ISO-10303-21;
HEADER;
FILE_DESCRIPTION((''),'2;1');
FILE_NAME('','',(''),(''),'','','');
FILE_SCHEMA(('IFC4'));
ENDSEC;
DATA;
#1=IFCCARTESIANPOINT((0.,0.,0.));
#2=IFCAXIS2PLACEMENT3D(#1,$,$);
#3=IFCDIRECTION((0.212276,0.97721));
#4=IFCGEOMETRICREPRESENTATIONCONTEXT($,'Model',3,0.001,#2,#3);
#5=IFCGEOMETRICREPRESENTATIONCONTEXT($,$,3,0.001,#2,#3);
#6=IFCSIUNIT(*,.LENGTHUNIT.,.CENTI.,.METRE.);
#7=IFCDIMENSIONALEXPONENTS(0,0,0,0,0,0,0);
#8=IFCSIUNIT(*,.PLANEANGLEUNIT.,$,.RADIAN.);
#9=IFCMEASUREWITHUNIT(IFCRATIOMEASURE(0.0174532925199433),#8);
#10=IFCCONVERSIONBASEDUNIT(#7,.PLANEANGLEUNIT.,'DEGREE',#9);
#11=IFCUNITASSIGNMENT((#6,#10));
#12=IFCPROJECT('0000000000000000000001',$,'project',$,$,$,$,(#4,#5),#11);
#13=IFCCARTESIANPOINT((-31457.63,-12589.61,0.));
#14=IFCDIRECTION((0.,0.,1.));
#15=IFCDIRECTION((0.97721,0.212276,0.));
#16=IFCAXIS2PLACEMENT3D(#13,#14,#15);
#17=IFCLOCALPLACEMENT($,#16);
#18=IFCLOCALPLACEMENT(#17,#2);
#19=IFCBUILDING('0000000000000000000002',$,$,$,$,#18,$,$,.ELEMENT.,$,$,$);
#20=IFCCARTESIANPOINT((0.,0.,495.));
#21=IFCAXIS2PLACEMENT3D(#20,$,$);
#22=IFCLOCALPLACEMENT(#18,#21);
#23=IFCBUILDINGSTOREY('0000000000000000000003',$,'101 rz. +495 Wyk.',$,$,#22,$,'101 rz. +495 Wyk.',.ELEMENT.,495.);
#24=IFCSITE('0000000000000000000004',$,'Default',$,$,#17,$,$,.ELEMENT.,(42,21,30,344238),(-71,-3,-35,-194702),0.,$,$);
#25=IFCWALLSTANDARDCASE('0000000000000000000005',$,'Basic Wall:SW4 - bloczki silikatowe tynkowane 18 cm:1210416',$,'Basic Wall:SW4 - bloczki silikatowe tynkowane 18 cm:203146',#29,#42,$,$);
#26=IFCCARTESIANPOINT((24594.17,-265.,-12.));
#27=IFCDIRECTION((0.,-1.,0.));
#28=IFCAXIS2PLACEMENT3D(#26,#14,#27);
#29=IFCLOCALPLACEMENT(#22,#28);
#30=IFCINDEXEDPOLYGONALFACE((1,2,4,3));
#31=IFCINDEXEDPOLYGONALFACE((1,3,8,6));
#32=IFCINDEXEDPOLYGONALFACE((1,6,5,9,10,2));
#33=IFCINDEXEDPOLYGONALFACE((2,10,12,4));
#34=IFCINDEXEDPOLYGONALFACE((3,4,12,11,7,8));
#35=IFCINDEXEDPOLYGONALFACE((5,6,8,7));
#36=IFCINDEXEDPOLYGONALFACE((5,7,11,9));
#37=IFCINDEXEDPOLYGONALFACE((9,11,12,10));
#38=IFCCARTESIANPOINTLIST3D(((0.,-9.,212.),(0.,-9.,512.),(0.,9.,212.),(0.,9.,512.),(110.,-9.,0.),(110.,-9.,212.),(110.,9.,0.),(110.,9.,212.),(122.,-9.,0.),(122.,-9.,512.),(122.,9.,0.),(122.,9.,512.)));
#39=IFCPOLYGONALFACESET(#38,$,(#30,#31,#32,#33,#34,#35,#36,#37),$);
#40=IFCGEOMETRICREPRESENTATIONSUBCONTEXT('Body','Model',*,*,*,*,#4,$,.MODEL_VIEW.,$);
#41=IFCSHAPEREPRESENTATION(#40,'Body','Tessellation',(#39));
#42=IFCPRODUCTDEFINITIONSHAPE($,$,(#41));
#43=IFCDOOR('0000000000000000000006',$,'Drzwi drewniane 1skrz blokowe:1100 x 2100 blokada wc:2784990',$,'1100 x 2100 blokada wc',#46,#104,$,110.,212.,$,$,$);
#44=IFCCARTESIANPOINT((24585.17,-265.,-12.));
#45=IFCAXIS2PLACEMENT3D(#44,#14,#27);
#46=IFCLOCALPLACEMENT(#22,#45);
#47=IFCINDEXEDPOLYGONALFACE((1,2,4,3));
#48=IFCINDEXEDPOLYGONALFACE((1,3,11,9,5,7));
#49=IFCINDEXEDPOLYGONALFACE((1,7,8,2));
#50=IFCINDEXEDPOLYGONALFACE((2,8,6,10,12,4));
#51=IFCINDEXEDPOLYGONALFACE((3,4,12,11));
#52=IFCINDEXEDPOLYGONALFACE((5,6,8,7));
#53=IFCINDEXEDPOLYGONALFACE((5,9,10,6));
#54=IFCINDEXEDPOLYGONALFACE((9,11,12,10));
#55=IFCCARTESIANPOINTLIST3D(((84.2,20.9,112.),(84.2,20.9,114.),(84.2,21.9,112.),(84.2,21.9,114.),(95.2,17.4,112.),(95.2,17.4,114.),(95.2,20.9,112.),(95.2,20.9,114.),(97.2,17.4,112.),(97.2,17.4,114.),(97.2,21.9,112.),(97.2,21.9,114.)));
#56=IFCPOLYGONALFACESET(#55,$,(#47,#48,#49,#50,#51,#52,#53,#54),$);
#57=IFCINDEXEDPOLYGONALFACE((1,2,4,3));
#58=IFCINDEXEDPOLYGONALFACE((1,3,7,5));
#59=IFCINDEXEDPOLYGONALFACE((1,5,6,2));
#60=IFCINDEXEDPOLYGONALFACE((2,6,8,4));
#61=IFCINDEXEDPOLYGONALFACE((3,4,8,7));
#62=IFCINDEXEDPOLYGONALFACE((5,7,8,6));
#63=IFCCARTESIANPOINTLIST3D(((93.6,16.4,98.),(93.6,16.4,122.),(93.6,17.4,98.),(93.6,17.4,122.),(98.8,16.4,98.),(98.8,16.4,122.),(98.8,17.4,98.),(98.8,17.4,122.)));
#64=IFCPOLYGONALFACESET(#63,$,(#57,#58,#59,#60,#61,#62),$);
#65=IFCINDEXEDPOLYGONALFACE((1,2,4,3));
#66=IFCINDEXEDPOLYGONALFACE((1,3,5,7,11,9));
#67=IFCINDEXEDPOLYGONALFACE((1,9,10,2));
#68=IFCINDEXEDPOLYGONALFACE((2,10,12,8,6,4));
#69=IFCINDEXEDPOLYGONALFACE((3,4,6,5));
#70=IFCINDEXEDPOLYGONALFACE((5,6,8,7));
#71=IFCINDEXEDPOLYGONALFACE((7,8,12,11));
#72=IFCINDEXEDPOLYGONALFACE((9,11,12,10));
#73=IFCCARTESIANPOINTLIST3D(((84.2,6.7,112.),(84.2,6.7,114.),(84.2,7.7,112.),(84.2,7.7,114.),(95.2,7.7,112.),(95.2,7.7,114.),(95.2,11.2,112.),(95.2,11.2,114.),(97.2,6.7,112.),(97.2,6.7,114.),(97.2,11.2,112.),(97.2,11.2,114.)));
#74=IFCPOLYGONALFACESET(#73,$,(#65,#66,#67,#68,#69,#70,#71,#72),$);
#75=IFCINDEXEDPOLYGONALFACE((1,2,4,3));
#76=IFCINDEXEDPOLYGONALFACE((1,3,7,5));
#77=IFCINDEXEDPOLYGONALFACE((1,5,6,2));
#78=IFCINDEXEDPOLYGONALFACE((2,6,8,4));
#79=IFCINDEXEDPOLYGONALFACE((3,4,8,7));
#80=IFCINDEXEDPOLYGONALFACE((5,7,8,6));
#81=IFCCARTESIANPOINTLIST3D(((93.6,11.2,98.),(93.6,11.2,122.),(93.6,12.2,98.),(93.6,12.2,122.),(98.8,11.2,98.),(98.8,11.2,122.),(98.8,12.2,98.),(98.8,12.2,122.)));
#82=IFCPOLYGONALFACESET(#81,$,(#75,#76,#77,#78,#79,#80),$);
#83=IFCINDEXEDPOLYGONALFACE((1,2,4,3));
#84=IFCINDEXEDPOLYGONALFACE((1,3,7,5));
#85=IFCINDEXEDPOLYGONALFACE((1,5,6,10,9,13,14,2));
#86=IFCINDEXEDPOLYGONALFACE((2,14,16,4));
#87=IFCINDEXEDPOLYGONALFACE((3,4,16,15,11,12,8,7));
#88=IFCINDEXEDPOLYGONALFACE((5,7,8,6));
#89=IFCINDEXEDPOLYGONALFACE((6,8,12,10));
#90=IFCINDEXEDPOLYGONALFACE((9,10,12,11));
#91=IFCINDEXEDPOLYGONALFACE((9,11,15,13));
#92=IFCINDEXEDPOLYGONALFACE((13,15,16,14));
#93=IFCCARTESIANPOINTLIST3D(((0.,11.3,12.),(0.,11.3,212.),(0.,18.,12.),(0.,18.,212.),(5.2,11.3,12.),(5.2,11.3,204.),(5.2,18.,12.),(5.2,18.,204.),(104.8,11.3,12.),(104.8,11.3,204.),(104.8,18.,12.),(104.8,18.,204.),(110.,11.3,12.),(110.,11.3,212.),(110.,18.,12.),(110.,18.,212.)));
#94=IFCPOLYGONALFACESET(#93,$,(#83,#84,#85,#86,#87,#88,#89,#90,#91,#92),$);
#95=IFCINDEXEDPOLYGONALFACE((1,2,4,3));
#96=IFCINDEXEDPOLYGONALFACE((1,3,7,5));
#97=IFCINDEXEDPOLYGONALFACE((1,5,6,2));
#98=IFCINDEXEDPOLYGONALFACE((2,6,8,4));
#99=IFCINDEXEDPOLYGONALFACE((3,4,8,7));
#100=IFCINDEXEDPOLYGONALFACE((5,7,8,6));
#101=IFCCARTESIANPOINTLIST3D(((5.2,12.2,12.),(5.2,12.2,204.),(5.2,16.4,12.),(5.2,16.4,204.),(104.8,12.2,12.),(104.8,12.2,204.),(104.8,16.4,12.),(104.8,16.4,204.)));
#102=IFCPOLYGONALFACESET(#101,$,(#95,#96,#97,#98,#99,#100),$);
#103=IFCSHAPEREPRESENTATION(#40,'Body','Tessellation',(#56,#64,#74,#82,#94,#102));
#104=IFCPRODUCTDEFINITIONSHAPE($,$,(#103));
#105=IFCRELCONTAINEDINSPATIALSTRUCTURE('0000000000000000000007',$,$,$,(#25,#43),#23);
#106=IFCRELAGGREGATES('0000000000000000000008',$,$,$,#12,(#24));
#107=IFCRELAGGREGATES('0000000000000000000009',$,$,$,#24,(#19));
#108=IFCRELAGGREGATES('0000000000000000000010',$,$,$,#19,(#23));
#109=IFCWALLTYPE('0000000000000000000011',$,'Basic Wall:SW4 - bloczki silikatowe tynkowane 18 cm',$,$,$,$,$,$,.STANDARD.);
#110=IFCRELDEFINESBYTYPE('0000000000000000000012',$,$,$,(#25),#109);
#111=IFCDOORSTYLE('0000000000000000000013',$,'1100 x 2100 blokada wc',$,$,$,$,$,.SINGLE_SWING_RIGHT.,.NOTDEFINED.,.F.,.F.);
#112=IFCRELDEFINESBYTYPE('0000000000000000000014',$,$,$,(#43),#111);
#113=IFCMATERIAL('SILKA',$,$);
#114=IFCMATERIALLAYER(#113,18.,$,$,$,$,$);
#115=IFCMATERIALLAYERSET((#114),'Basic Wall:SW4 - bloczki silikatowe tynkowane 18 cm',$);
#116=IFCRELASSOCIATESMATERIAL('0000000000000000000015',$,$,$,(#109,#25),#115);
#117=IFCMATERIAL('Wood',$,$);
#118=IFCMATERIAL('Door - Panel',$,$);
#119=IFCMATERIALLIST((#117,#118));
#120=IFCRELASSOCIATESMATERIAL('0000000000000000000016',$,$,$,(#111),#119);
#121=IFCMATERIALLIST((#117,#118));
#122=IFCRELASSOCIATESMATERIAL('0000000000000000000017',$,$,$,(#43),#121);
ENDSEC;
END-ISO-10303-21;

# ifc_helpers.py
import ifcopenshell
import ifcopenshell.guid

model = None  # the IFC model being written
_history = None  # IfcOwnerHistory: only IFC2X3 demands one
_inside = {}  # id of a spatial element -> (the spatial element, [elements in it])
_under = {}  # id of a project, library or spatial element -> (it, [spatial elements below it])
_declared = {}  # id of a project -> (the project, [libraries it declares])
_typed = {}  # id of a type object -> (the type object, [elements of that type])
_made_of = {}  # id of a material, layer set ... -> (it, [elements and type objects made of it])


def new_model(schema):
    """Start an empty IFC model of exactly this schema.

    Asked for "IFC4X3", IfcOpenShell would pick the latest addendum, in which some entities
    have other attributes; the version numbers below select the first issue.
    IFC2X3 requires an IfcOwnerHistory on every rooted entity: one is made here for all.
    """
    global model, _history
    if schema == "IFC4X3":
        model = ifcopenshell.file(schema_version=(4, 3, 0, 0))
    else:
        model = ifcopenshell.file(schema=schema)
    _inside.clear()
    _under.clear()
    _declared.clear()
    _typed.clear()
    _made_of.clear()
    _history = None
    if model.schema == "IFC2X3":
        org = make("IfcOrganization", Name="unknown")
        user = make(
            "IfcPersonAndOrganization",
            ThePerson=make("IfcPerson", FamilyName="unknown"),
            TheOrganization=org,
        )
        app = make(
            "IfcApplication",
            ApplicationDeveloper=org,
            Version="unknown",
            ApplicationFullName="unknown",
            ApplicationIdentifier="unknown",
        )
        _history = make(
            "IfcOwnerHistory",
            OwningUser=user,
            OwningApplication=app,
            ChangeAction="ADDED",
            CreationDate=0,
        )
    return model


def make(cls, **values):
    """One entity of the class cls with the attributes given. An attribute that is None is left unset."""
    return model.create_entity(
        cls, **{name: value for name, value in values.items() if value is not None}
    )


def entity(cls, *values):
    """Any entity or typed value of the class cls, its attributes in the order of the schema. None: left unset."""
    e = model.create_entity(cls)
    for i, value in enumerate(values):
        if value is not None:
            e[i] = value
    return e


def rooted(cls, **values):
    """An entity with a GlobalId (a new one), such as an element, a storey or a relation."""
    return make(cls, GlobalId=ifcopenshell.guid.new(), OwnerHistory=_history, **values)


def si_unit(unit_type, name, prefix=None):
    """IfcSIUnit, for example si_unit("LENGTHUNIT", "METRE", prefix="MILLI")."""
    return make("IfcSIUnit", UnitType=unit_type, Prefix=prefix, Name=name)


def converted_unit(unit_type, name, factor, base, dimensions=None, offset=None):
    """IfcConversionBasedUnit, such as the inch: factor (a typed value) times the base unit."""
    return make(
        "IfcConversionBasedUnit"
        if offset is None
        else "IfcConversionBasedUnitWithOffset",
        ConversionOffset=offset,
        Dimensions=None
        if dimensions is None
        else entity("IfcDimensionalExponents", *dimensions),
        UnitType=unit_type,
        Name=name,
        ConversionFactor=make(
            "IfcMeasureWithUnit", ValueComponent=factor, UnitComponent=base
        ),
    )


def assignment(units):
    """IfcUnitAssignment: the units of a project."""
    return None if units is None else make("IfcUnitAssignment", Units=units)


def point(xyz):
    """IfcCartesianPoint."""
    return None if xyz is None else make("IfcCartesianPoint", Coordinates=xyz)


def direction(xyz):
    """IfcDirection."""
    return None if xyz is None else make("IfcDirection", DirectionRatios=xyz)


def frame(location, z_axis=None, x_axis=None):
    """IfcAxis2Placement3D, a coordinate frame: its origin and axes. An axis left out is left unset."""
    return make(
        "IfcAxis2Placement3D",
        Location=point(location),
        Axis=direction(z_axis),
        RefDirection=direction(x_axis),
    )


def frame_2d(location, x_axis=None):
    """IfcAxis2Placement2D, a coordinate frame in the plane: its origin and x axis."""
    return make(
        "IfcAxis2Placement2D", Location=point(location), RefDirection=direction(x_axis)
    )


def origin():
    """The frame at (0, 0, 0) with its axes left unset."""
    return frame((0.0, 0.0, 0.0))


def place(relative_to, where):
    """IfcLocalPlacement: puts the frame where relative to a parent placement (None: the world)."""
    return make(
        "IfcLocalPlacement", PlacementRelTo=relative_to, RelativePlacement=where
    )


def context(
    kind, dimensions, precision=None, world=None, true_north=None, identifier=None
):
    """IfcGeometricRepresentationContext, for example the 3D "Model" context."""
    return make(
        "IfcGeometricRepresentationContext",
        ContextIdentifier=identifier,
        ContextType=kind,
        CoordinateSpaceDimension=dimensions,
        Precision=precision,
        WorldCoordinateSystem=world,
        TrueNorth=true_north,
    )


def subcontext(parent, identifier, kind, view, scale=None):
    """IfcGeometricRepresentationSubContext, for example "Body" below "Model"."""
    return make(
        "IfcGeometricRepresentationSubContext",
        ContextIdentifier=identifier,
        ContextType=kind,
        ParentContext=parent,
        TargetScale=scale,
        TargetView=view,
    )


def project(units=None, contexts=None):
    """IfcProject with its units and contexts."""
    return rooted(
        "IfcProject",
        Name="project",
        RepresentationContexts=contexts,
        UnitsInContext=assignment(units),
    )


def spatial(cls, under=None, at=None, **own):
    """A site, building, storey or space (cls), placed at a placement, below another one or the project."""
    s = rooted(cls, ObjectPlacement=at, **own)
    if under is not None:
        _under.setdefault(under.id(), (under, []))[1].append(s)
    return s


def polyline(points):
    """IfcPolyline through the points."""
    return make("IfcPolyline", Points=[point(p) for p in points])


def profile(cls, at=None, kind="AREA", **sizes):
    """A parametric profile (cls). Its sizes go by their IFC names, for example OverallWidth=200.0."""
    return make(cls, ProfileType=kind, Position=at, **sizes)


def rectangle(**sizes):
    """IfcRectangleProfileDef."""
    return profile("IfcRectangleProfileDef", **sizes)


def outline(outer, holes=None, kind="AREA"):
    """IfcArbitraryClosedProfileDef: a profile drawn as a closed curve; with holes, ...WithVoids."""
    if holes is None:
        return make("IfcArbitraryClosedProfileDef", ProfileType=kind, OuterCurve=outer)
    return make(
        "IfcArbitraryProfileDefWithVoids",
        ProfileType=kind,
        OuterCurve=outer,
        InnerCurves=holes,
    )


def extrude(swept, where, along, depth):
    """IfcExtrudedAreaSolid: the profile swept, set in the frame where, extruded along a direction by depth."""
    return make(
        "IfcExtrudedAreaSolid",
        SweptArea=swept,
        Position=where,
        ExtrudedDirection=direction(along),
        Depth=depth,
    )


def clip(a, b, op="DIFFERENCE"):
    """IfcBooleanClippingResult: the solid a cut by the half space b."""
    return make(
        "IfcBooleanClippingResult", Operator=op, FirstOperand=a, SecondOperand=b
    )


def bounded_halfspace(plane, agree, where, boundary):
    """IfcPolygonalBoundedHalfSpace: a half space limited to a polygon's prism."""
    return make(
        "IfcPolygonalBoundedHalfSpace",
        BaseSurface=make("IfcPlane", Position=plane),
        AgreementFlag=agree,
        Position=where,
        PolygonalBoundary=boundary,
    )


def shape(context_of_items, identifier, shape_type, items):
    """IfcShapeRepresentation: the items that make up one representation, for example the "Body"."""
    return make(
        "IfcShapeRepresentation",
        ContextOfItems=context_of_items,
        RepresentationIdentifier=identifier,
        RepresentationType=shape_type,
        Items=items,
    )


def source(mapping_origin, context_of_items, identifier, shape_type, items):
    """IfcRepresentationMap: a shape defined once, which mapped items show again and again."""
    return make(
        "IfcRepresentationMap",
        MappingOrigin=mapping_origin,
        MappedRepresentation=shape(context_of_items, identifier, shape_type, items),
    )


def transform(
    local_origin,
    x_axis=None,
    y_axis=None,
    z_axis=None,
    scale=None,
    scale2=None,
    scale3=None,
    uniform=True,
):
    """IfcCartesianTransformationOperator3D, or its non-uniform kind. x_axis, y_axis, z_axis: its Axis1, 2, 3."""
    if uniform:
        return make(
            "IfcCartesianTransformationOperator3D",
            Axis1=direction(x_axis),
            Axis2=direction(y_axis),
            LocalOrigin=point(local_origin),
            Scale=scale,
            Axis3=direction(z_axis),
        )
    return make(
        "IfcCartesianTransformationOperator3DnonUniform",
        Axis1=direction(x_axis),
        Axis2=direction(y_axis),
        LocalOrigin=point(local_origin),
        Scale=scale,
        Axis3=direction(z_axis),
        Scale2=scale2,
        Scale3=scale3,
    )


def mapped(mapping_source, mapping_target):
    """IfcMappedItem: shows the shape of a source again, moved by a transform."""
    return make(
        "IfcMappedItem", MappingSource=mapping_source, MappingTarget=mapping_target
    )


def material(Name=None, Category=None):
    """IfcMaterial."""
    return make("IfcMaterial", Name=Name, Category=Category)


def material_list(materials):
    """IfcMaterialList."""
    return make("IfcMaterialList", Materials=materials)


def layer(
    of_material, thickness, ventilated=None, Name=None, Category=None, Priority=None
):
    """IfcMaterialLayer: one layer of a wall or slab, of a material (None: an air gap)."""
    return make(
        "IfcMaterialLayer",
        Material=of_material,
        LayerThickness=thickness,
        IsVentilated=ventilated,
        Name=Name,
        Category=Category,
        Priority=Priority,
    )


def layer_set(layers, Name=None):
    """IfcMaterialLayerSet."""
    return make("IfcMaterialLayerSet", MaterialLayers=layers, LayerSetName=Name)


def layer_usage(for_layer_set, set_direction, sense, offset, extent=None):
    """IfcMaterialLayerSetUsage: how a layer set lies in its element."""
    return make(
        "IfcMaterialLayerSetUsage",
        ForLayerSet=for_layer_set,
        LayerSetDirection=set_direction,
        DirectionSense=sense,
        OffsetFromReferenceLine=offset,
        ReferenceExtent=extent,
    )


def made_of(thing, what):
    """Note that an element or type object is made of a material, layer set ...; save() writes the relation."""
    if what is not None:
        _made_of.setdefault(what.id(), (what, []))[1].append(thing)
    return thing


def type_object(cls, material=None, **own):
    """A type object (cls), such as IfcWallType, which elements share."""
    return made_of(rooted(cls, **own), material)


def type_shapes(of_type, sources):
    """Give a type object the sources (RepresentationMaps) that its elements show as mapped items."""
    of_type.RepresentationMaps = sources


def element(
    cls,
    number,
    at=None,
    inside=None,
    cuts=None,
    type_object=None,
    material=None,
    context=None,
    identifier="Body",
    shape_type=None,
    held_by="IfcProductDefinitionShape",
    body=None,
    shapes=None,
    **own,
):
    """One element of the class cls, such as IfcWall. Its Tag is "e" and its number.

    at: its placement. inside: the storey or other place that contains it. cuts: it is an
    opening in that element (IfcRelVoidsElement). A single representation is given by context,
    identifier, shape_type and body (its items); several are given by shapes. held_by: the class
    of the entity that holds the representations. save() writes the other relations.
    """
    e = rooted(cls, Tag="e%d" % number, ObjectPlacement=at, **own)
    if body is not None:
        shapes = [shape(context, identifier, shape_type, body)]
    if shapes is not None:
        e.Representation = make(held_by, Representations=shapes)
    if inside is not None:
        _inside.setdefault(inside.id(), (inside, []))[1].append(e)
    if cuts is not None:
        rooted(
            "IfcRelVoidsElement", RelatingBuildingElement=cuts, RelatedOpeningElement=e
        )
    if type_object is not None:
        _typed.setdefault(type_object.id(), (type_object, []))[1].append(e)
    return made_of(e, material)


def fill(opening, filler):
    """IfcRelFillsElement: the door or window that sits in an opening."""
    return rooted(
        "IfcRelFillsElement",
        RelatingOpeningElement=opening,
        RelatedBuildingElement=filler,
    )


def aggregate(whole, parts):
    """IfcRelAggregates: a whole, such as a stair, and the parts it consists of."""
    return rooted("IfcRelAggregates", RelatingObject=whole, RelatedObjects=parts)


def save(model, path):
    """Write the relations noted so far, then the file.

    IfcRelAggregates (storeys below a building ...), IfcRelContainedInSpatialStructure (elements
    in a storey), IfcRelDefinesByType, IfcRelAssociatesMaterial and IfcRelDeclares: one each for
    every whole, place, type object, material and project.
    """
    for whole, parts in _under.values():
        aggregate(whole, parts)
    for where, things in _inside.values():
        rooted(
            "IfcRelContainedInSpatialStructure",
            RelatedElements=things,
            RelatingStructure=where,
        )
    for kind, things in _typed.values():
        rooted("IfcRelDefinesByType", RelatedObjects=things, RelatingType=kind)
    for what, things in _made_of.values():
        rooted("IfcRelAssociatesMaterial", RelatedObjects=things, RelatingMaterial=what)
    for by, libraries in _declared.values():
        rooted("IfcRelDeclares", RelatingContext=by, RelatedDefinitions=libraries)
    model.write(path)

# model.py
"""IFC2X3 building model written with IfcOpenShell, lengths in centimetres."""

from ifc_helpers import new_model, entity, si_unit, converted_unit, direction, frame, frame_2d, origin, place, context, subcontext, project, spatial, polyline, rectangle, outline, extrude, clip, bounded_halfspace, source, transform, mapped, material, material_list, layer, layer_set, layer_usage, type_object, type_shapes, element, fill, save


model = new_model("IFC2X3")

# Units and contexts
model_context = context("Model", 3, precision=0.001, world=origin(), true_north=direction((0.212276, 0.97721)))
context_of_model = context(None, 3, precision=0.001, world=origin(), true_north=direction((0.212276, 0.97721)))
body_context = subcontext(model_context, "Body", "Model", "MODEL_VIEW")
ifc_project = project(units=[si_unit("LENGTHUNIT", "METRE", prefix="CENTI"), converted_unit("PLANEANGLEUNIT", "DEGREE", entity("IfcRatioMeasure", 0.0174532925199433), si_unit("PLANEANGLEUNIT", "RADIAN"), dimensions=[0, 0, 0, 0, 0, 0, 0])], contexts=[model_context, context_of_model])

# Site, building, storey
site_placement = place(None, frame((-31457.63, -12589.61, 0.0), z_axis=(0.0, 0.0, 1.0), x_axis=(0.97721, 0.212276, 0.0)))
site = spatial("IfcSite", under=ifc_project, at=site_placement, Name="Default", CompositionType="ELEMENT", RefLatitude=(42, 21, 30, 344238), RefLongitude=(-71, -3, -35, -194702), RefElevation=0.0)
building_placement = place(site_placement, origin())
building = spatial("IfcBuilding", under=site, at=building_placement, CompositionType="ELEMENT")
storey_placement = place(building_placement, frame((0.0, 0.0, 495.0)))
storey = spatial("IfcBuildingStorey", under=building, at=storey_placement, Name="101 rz. +495 Wyk.", LongName="101 rz. +495 Wyk.", CompositionType="ELEMENT", Elevation=495.0)

# Shared definitions
ifc_material_1 = material(Name="SILKA")
ifc_layer_1 = layer(ifc_material_1, 18.0)
ifc_layer_set_1 = layer_set([ifc_layer_1], Name="Basic Wall:SW4 - bloczki silikatowe tynkowane 18 cm")
wall_type_1 = type_object("IfcWallType", Name="Basic Wall:SW4 - bloczki silikatowe tynkowane 18 cm", PredefinedType="STANDARD", material=ifc_layer_set_1)

# Shared definitions
ifc_material_2 = material(Name="Door - Panel")
ifc_material_3 = material(Name="Wood")

# Wall, opening, door
ifc_layer_usage_1 = layer_usage(ifc_layer_set_1, "AXIS2", "NEGATIVE", 9.0)
wall_1_placement = place(storey_placement, frame((24594.17, -265.0, -12.0), z_axis=(0.0, 0.0, 1.0), x_axis=(0.0, -1.0, 0.0)))
wall_1 = element("IfcWallStandardCase", 1, at=wall_1_placement, inside=storey, type_object=wall_type_1, material=ifc_layer_usage_1, Name="Basic Wall:SW4 - bloczki silikatowe tynkowane 18 cm:1210416", ObjectType="Basic Wall:SW4 - bloczki silikatowe tynkowane 18 cm:203146", context=body_context, shape_type="Clipping", body=[
    clip(extrude(rectangle(XDim=122.0, YDim=18.0, at=frame_2d((61.0, 0.0), x_axis=(-1.0, 0.0))), origin(), (0.0, 0.0, 1.0), 537.0), bounded_halfspace(frame((0.0, -9.0, 512.0), z_axis=(0.0, 0.0, -1.0), x_axis=(0.0, 1.0, 0.0)), True, frame((0.0, -9.0, 512.0)), polyline([(0.0, 0.0), (122.0, 0.0), (122.0, 18.0), (0.0, 18.0), (0.0, 0.0)]))),
])
opening_1_placement = place(wall_1_placement, frame((110.0, -9.0, 0.0), z_axis=(0.0, 0.0, 1.0), x_axis=(0.0, 1.0, 0.0)))
opening_1 = element("IfcOpeningElement", 2, at=opening_1_placement, cuts=wall_1, ObjectType="Opening", context=body_context, shape_type="SweptSolid", body=[
    extrude(rectangle(XDim=212.0, YDim=110.0, at=frame_2d((0.0, 0.0), x_axis=(1.0, 0.0))), frame((0.0, 55.0, 106.0), z_axis=(1.0, 0.0, 0.0), x_axis=(0.0, 0.0, -1.0)), (0.0, 0.0, 1.0), 18.0),
])
ifc_material_list_1 = material_list([ifc_material_3, ifc_material_2])
ifc_material_list_2 = material_list([ifc_material_3, ifc_material_2])
door_style_1 = type_object("IfcDoorStyle", Name="1100 x 2100 blokada wc", ConstructionType="NOTDEFINED", OperationType="SINGLE_SWING_RIGHT", ParameterTakesPrecedence=False, Sizeable=False, material=ifc_material_list_2)
shared_shape_1 = source(origin(), body_context, "Body", "SweptSolid", [
    extrude(outline(polyline([(-5.0, -1.83), (8.0, -1.83), (8.0, -0.83), (-3.0, -0.83), (-3.0, 2.67), (-5.0, 2.67), (-5.0, -1.83)])), frame((92.2, 20.07, 112.0), z_axis=(0.0, 0.0, 1.0), x_axis=(-1.0, 0.0, 0.0)), (0.0, 0.0, 1.0), 2.0),
    extrude(rectangle(XDim=1.0, YDim=5.2, at=frame_2d((0.0, 0.0), x_axis=(1.0, 0.0))), frame((96.2, 16.9, 98.0), z_axis=(0.0, 0.0, 1.0), x_axis=(0.0, -1.0, 0.0)), (0.0, 0.0, 1.0), 24.0),
    extrude(outline(polyline([(-1.83, -5.0), (2.67, -5.0), (2.67, -3.0), (-0.83, -3.0), (-0.83, 8.0), (-1.83, 8.0), (-1.83, -5.0)])), frame((92.2, 8.53, 112.0), z_axis=(0.0, 0.0, 1.0), x_axis=(0.0, 1.0, 0.0)), (0.0, 0.0, 1.0), 2.0),
    extrude(rectangle(XDim=5.2, YDim=1.0, at=frame_2d((0.0, 0.0), x_axis=(1.0, 0.0))), frame((96.2, 11.7, 98.0)), (0.0, 0.0, 1.0), 24.0),
    extrude(outline(polyline([(-102.0, -55.0), (98.0, -55.0), (98.0, -49.8), (-94.0, -49.8), (-94.0, 49.8), (98.0, 49.8), (98.0, 55.0), (-102.0, 55.0), (-102.0, -55.0)])), frame((55.0, 18.0, 110.0), z_axis=(0.0, -1.0, 0.0), x_axis=(0.0, 0.0, -1.0)), (0.0, 0.0, 1.0), 6.7),
    extrude(rectangle(XDim=99.6, YDim=4.2, at=frame_2d((0.0, 0.0), x_axis=(1.0, 0.0))), frame((55.0, 14.3, 12.0)), (0.0, 0.0, 1.0), 192.0),
])
type_shapes(door_style_1, [shared_shape_1])
door_1_placement = place(storey_placement, frame((24585.17, -265.0, -12.0), z_axis=(0.0, 0.0, 1.0), x_axis=(0.0, -1.0, 0.0)))
door_1 = element("IfcDoor", 3, at=door_1_placement, inside=storey, type_object=door_style_1, material=ifc_material_list_1, Name="Drzwi drewniane 1skrz blokowe:1100 x 2100 blokada wc:2784990", ObjectType="1100 x 2100 blokada wc", OverallHeight=110.0, OverallWidth=212.0, context=body_context, shape_type="MappedRepresentation", body=[
    mapped(shared_shape_1, transform((0.0, 0.0, 0.0), scale=1.0)),
])
fill(opening_1, door_1)

save(model, "model.ifc")
